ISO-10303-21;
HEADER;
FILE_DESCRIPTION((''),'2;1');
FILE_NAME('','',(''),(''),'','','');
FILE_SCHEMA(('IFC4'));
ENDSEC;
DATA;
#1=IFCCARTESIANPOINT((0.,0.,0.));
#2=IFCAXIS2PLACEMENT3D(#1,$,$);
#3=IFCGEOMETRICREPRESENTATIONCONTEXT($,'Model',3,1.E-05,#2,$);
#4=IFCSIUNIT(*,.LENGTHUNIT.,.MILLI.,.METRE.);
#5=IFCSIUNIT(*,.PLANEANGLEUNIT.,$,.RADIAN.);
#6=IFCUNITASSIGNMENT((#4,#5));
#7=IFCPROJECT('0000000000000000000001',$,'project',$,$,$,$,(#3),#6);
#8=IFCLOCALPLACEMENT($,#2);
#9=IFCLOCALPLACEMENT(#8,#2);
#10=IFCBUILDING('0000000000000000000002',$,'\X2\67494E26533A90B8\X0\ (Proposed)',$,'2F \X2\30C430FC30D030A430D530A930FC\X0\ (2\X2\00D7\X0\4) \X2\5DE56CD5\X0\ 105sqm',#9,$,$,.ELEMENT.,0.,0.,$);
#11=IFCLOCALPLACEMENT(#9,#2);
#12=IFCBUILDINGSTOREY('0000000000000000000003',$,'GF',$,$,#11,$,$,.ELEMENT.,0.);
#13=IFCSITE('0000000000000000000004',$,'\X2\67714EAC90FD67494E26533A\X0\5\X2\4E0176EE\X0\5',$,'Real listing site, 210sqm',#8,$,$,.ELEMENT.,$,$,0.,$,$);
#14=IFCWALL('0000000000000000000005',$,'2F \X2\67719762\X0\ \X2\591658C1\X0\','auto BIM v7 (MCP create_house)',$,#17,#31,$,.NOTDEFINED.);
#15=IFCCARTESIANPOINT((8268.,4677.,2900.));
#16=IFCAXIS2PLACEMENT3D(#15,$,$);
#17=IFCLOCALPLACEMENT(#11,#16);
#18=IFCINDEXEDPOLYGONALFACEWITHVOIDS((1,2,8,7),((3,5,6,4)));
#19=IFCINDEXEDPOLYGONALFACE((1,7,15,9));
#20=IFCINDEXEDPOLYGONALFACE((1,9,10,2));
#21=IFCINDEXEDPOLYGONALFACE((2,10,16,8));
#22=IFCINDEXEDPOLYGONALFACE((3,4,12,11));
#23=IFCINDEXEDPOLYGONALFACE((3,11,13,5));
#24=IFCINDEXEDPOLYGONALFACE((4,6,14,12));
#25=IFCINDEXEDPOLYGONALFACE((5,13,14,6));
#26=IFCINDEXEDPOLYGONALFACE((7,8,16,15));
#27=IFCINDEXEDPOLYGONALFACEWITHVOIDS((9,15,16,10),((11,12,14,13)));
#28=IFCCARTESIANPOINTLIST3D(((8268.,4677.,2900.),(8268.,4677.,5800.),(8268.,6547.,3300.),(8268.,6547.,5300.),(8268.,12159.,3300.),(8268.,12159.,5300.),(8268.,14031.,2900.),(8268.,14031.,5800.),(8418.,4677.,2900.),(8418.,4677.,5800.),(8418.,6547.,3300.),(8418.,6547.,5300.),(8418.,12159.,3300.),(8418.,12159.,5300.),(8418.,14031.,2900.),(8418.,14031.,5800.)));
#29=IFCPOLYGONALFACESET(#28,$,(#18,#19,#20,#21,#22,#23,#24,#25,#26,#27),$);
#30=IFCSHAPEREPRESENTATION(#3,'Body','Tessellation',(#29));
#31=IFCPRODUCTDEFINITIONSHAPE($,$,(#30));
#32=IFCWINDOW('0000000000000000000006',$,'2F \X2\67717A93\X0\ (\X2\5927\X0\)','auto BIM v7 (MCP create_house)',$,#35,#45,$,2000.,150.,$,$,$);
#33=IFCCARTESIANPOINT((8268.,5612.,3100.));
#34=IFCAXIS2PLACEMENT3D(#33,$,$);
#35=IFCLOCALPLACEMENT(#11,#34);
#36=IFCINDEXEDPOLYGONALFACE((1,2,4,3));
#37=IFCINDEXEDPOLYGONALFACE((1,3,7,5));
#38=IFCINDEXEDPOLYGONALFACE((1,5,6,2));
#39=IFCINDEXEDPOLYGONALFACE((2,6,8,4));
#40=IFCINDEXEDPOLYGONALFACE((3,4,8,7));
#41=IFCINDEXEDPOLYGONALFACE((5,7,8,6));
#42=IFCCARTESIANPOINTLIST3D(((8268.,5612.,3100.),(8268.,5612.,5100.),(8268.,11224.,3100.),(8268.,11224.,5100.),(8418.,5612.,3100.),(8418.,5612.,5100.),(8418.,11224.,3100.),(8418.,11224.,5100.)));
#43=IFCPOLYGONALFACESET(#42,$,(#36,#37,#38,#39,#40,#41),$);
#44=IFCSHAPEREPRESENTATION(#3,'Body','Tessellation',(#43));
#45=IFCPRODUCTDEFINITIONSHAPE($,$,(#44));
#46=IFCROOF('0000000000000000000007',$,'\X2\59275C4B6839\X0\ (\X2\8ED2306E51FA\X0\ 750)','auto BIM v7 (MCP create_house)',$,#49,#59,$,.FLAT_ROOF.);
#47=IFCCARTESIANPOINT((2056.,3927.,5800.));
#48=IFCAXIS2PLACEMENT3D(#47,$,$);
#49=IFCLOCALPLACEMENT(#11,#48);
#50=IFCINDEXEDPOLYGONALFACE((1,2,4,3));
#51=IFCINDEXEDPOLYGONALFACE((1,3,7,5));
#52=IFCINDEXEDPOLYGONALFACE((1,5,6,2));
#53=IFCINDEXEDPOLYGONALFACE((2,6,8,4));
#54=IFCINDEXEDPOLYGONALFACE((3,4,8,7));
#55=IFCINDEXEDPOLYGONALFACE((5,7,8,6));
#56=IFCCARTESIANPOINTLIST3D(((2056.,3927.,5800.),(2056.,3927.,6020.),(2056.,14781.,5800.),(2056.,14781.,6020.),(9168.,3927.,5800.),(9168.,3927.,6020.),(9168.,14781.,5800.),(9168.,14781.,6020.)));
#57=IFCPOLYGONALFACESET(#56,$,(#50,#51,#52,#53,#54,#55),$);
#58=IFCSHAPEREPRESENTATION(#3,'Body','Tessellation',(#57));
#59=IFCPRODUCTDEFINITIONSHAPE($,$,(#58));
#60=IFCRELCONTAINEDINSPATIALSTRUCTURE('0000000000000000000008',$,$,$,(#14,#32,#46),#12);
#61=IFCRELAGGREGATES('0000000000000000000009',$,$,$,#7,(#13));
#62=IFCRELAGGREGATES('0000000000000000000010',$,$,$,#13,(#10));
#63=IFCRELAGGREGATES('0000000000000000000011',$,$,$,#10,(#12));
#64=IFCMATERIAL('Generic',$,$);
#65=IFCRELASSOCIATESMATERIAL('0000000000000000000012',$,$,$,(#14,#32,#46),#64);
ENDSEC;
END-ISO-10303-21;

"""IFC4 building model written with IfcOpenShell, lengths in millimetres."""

from ifc_helpers import new_model, si_unit, frame, frame_2d, origin, place, context, project, spatial, rectangle, extrude, material, element, fill, save


model = new_model("IFC4")

# Units and contexts
model_context = context("Model", 3, precision=1e-05, world=origin())
ifc_project = project(units=[si_unit("LENGTHUNIT", "METRE", prefix="MILLI"), si_unit("PLANEANGLEUNIT", "RADIAN")], contexts=[model_context])

# Site, building, storey
site_placement = place(None, origin())
site = spatial("IfcSite", under=ifc_project, at=site_placement, Name="東京都杉並区5丁目5", ObjectType="Real listing site, 210sqm", CompositionType="ELEMENT", RefElevation=0.0)
building_placement = place(site_placement, origin())
building = spatial("IfcBuilding", under=site, at=building_placement, Name="杉並区邸 (Proposed)", ObjectType="2F ツーバイフォー (2×4) 工法 105sqm", CompositionType="ELEMENT", ElevationOfRefHeight=0.0, ElevationOfTerrain=0.0)
storey_placement = place(building_placement, origin())
storey = spatial("IfcBuildingStorey", under=building, at=storey_placement, Name="GF", CompositionType="ELEMENT", Elevation=0.0)

# Shared definitions
ifc_material = material(Name="Generic")

# Wall, opening, window
wall_1_placement = place(storey_placement, frame((8268.0, 4677.0, 2900.0)))
wall_1 = element("IfcWall", 1, at=wall_1_placement, inside=storey, material=ifc_material, Name="2F 東面 外壁", Description="auto BIM v7 (MCP create_house)", PredefinedType="NOTDEFINED", context=model_context, shape_type="SweptSolid", body=[
    extrude(rectangle(XDim=150.0, YDim=9354.0, at=frame_2d((75.0, 4677.0))), frame((8268.0, 4677.0, 2900.0)), (0.0, 0.0, 1.0), 2900.0),
])
opening_1_placement = place(storey_placement, frame((8268.0, 5612.0, 3100.0)))
opening_1 = element("IfcOpeningElement", 2, at=opening_1_placement, cuts=wall_1, PredefinedType="NOTDEFINED", context=model_context, shape_type="SweptSolid", body=[
    extrude(rectangle(XDim=150.0, YDim=5612.0, at=frame_2d((75.0, 2806.0))), frame((8268.0, 5612.0, 3100.0)), (0.0, 0.0, 1.0), 2000.0),
])
window_1_placement = place(storey_placement, frame((8268.0, 5612.0, 3100.0)))
window_1 = element("IfcWindow", 3, at=window_1_placement, inside=storey, material=ifc_material, Name="2F 東窓 (大)", Description="auto BIM v7 (MCP create_house)", OverallHeight=2000.0, OverallWidth=150.0, context=model_context, shape_type="SweptSolid", body=[
    extrude(rectangle(XDim=150.0, YDim=5612.0, at=frame_2d((75.0, 2806.0))), frame((8268.0, 5612.0, 3100.0)), (0.0, 0.0, 1.0), 2000.0),
])
fill(opening_1, window_1)

# Roof
roof_placement = place(storey_placement, frame((2056.0, 3927.0, 5800.0)))
element("IfcRoof", 4, at=roof_placement, inside=storey, material=ifc_material, Name="大屋根 (軒の出 750)", Description="auto BIM v7 (MCP create_house)", PredefinedType="FLAT_ROOF", context=model_context, shape_type="SweptSolid", body=[
    extrude(rectangle(XDim=7112.0, YDim=10854.0, at=frame_2d((3556.0, 5427.0))), frame((2056.0, 3927.0, 5800.0)), (0.0, 0.0, 1.0), 220.0),
])

save(model, "model.ifc")
